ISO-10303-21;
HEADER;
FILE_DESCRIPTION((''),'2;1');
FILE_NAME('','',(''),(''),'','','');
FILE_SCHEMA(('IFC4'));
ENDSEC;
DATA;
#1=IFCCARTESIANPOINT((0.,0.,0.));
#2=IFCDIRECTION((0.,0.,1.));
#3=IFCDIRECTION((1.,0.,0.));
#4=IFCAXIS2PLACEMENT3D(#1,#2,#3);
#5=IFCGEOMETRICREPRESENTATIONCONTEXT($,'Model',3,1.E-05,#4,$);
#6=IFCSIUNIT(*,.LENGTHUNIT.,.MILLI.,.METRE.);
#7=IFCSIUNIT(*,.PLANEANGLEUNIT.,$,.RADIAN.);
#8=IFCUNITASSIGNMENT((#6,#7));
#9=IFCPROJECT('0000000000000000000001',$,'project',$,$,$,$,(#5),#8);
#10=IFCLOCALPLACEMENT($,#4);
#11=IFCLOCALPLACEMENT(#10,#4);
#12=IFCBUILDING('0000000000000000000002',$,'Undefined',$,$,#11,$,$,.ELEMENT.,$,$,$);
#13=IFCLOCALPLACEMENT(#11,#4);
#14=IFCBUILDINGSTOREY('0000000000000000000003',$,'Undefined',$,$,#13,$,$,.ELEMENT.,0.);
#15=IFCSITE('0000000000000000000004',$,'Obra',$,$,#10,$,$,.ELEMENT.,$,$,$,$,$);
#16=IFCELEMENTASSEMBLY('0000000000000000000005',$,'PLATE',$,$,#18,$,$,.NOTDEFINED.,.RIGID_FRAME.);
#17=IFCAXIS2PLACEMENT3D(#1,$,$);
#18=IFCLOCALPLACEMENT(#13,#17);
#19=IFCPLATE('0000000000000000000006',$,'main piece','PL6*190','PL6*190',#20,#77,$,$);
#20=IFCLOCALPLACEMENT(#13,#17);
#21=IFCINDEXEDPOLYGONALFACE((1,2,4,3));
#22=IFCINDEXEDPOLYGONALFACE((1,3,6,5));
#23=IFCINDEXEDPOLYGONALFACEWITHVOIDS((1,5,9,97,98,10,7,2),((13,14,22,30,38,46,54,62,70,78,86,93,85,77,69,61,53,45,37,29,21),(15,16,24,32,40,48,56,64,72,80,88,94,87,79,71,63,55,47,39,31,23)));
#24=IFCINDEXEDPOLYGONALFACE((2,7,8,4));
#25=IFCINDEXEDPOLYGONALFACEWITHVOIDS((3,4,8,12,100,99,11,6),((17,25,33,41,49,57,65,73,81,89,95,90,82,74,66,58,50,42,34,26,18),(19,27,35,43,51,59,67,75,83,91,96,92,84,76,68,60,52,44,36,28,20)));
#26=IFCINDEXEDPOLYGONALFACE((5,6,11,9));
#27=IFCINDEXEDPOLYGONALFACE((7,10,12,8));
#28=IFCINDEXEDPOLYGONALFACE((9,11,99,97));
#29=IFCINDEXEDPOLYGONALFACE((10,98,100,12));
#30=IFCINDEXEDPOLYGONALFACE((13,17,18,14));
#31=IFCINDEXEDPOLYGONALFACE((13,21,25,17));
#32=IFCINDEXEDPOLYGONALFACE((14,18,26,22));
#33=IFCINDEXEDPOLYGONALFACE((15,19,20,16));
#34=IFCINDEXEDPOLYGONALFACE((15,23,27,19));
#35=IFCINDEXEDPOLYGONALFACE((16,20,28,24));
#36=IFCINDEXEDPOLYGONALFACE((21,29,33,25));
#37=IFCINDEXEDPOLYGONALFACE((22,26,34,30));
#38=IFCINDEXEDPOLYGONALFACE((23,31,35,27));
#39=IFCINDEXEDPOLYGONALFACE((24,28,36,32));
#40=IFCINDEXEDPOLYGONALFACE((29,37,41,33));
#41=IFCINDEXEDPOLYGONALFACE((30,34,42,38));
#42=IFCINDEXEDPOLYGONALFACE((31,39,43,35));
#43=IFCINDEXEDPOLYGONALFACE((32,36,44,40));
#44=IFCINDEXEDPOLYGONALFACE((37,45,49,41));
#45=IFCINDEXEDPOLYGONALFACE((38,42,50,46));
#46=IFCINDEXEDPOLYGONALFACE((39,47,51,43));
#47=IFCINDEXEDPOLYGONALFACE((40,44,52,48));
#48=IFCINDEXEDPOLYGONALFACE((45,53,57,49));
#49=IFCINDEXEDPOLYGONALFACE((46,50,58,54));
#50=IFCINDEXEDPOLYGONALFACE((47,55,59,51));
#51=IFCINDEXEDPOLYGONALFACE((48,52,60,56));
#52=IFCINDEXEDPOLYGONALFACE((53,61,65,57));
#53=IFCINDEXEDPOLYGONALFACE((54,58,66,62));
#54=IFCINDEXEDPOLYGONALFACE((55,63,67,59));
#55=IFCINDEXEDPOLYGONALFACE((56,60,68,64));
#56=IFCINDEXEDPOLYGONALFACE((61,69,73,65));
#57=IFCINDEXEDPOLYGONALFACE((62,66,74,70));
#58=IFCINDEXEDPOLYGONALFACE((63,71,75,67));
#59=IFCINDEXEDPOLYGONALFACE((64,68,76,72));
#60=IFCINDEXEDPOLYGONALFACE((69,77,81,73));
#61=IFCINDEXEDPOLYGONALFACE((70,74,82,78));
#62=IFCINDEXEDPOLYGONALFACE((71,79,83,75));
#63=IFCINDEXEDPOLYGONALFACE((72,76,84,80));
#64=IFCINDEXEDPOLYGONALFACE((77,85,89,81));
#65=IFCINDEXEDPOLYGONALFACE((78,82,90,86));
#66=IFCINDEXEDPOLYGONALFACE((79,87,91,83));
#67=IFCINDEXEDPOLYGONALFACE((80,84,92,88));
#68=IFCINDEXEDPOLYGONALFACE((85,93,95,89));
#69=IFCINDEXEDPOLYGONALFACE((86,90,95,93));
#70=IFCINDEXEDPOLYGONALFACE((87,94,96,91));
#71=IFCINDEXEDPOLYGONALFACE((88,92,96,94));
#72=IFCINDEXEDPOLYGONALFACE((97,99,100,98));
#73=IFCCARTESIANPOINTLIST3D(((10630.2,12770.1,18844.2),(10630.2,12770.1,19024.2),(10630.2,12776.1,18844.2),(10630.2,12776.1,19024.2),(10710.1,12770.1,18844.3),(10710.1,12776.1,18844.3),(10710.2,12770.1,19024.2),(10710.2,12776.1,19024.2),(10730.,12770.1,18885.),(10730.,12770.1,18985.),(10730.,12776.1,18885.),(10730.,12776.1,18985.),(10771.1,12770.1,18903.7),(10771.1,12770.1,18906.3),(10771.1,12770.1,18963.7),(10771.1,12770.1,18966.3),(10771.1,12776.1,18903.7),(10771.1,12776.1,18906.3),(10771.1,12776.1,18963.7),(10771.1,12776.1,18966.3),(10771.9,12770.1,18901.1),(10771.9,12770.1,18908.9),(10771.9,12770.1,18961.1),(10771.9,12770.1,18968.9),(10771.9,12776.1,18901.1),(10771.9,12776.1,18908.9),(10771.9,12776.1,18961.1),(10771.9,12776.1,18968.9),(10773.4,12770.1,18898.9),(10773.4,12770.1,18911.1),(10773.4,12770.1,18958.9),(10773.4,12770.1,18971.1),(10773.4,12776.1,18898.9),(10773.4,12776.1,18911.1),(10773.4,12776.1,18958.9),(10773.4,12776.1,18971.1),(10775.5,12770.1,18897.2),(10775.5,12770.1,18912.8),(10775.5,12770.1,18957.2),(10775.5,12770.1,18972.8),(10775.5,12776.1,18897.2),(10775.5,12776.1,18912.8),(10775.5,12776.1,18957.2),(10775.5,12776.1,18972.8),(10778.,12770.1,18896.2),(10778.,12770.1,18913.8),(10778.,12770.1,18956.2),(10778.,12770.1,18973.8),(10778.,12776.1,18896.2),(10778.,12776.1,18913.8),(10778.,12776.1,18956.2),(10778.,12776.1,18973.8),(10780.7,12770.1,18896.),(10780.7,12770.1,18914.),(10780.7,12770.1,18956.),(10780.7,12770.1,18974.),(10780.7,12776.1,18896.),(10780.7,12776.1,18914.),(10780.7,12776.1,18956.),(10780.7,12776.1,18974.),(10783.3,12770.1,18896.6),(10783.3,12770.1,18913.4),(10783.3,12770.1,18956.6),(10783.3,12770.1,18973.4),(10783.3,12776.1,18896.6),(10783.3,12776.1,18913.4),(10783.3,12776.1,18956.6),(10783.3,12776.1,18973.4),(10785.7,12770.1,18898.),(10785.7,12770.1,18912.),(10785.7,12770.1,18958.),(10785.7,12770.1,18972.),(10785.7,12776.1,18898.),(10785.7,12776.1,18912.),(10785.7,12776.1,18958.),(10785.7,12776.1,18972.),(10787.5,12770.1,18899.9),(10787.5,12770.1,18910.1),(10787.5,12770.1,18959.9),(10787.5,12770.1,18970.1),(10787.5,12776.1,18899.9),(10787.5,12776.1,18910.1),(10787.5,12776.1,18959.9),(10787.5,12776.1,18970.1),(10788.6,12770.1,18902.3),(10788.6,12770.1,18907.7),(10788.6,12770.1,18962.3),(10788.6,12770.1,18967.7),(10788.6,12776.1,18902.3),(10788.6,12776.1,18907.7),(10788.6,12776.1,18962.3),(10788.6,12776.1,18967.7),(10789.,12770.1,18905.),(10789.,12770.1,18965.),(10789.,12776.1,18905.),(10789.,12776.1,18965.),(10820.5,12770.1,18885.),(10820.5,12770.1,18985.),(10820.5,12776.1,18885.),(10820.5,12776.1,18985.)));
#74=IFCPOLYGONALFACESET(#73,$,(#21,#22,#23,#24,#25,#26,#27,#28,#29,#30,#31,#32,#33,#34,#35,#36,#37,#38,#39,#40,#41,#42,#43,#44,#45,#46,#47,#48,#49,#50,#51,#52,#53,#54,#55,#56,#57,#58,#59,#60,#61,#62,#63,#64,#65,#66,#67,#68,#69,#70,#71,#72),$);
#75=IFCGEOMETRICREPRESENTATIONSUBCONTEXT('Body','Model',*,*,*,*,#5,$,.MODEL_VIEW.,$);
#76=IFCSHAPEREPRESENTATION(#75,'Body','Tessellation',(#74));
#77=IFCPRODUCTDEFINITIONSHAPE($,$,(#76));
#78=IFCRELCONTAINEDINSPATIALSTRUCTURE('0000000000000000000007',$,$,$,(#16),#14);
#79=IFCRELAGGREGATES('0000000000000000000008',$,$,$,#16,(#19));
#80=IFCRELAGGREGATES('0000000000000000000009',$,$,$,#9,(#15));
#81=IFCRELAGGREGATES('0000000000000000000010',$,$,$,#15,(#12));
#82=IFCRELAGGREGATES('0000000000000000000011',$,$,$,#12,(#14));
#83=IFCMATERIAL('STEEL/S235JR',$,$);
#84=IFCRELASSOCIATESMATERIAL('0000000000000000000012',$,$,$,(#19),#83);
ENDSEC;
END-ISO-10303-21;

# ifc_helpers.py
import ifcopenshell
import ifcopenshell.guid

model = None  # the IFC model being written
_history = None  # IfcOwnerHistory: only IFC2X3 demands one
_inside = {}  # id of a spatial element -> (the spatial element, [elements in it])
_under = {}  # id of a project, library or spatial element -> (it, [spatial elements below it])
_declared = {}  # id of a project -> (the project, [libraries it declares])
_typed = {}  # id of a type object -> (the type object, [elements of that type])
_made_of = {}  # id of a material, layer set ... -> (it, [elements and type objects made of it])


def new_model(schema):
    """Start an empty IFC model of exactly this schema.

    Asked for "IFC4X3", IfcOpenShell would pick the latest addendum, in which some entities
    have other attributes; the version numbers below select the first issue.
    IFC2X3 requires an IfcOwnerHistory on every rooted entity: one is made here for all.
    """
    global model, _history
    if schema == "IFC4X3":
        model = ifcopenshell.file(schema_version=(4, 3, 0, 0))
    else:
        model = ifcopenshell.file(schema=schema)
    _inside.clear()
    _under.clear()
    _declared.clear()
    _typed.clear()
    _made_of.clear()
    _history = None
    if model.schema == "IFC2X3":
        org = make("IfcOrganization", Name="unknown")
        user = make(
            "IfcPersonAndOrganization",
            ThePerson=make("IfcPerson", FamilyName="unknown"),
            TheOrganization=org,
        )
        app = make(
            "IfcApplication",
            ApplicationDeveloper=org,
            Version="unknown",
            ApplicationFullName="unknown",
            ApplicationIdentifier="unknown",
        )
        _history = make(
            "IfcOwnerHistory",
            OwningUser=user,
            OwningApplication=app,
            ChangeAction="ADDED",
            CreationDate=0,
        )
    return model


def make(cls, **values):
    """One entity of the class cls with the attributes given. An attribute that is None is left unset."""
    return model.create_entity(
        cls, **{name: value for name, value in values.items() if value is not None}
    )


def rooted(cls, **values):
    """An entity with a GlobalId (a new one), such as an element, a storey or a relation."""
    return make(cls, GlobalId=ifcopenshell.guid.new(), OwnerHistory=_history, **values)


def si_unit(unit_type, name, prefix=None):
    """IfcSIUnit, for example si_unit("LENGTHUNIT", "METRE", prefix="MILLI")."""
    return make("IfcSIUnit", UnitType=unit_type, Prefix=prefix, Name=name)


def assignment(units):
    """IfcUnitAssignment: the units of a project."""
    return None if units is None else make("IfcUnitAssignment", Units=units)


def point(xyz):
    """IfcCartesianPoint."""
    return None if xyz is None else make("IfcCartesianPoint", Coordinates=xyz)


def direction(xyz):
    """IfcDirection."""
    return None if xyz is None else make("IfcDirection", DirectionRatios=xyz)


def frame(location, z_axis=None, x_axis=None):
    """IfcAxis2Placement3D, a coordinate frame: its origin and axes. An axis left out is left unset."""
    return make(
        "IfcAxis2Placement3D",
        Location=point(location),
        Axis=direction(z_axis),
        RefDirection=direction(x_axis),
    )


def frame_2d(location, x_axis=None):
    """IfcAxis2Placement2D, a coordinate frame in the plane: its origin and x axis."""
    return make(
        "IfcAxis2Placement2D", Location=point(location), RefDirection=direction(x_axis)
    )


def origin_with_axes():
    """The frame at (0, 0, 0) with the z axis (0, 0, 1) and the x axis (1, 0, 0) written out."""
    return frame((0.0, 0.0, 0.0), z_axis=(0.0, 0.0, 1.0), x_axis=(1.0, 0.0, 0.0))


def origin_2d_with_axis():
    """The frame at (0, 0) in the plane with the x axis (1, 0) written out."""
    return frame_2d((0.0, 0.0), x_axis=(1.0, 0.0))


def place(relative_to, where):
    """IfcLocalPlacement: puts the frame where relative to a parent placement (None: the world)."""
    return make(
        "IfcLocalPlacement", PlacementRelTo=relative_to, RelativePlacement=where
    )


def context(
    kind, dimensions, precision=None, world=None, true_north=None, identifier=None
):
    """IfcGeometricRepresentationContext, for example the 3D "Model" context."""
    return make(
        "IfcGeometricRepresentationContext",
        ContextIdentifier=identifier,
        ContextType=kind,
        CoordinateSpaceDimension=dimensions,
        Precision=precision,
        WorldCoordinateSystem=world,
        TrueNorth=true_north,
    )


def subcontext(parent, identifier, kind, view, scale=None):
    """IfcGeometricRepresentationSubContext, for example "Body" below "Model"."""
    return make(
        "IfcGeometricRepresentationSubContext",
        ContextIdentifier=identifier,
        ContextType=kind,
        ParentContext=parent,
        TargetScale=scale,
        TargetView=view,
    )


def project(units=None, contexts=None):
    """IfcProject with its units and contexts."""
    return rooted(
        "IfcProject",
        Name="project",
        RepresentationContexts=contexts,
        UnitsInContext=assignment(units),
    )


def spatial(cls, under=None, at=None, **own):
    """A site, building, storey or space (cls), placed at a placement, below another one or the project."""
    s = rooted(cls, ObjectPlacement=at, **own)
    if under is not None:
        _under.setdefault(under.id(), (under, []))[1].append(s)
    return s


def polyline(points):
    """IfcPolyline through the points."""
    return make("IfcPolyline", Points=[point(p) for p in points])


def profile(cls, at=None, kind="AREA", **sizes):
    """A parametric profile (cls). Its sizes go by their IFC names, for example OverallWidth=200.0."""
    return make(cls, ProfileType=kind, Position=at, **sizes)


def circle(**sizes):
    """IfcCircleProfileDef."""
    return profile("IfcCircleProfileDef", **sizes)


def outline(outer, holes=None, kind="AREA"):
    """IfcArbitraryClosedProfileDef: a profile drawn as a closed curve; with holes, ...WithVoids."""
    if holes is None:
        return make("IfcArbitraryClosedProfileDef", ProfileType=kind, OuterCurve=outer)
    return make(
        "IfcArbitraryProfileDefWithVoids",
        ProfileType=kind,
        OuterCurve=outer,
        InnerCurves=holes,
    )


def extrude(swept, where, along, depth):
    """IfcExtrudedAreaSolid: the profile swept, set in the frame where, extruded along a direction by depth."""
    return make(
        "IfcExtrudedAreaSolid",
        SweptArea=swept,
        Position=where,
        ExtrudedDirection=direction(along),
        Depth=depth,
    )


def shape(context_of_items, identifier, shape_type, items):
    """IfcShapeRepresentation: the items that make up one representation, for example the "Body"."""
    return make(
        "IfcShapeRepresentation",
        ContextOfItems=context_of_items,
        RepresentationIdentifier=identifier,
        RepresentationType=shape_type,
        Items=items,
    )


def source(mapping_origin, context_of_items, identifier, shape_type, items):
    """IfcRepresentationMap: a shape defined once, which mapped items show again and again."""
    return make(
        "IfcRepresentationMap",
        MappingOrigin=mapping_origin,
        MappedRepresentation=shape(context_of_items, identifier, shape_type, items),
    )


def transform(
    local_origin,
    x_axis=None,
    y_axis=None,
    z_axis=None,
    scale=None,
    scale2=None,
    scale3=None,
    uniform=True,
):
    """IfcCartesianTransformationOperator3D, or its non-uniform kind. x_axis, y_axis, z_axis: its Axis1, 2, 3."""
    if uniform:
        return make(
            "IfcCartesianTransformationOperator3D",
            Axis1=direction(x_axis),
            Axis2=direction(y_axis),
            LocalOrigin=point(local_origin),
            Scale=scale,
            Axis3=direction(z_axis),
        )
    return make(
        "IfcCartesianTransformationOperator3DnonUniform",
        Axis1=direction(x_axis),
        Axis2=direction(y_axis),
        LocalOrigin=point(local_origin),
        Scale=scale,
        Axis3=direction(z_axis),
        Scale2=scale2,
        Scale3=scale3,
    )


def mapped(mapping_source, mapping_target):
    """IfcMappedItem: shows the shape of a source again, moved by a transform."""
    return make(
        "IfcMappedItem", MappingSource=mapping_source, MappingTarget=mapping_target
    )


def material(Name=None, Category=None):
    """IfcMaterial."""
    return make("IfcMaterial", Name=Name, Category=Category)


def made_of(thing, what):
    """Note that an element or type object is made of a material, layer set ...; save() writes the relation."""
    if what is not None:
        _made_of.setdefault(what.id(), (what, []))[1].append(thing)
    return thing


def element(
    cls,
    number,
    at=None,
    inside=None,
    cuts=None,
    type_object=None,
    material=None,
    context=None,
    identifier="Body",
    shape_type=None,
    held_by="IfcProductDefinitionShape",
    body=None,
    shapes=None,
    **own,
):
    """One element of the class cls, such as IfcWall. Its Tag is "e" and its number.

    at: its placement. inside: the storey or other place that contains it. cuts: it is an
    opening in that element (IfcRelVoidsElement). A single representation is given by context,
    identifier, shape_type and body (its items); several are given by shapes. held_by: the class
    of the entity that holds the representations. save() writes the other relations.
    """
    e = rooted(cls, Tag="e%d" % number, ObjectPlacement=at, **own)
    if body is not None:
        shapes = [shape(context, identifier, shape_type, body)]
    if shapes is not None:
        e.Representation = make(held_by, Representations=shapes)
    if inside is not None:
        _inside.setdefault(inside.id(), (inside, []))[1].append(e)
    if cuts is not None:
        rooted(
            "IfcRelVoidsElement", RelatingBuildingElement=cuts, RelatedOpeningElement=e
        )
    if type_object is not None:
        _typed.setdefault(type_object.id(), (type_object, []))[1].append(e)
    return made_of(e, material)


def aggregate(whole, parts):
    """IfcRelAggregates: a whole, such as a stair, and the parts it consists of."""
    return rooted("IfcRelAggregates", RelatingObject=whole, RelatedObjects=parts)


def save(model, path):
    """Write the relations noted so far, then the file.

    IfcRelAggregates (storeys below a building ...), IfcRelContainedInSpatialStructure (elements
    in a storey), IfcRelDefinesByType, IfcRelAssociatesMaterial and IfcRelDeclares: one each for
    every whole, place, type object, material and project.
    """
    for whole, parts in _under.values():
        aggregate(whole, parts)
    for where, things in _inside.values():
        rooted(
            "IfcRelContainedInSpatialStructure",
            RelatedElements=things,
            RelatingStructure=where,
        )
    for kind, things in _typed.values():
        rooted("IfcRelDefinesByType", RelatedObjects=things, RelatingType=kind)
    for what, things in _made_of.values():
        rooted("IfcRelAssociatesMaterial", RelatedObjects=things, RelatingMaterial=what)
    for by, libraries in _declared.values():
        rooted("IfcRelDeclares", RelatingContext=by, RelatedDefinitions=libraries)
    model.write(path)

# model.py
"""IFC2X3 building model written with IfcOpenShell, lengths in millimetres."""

from ifc_helpers import new_model, si_unit, frame, origin_with_axes, origin_2d_with_axis, place, context, subcontext, project, spatial, polyline, circle, outline, extrude, source, transform, mapped, material, element, aggregate, save


model = new_model("IFC2X3")

# Units and contexts
model_context = context("Model", 3, precision=1e-05, world=origin_with_axes())
body_context = subcontext(model_context, "Body", "Model", "MODEL_VIEW")
ifc_project = project(units=[si_unit("LENGTHUNIT", "METRE", prefix="MILLI"), si_unit("PLANEANGLEUNIT", "RADIAN")], contexts=[model_context])

# Site, building, storey
site_placement = place(None, origin_with_axes())
site = spatial("IfcSite", under=ifc_project, at=site_placement, Name="Obra", CompositionType="ELEMENT")
building_placement = place(site_placement, origin_with_axes())
building = spatial("IfcBuilding", under=site, at=building_placement, Name="Undefined", CompositionType="ELEMENT")
storey_placement = place(building_placement, origin_with_axes())
storey = spatial("IfcBuildingStorey", under=building, at=storey_placement, Name="Undefined", CompositionType="ELEMENT", Elevation=0.0)

# Shared definitions
ifc_material_1 = material(Name="STEEL/S235JR")

# Element assembly, plate, opening
shared_shape_1 = source(origin_with_axes(), body_context, "Body", "SweptSolid", [
    extrude(circle(Radius=9.0, at=origin_2d_with_axis()), frame((0.0, -6.1, 0.0), z_axis=(0.0, 1.0, 0.0), x_axis=(1.0, 0.0, 0.0)), (0.0, 0.0, 1.0), 6.2),
])
assembly_1_placement = place(storey_placement, origin_with_axes())
assembly_1 = element("IfcElementAssembly", 1, at=assembly_1_placement, inside=storey, Name="PLATE", AssemblyPlace="NOTDEFINED", PredefinedType="RIGID_FRAME")
plate_1_placement = place(assembly_1_placement, frame((10630.2, 12773.1, 19024.2), z_axis=(0.0, -1.0, 0.0), x_axis=(0.0, 0.0, -1.0)))
plate_1 = element("IfcPlate", 2, at=plate_1_placement, material=ifc_material_1, Name="main piece", Description="PL6*190", ObjectType="PL6*190", context=body_context, shape_type="SweptSolid", body=[
    extrude(outline(polyline([(0.0, 0.0), (180.0, 0.0), (180.0, 79.9), (139.2, 99.8), (139.2, 190.3), (39.2, 190.3), (39.2, 99.8), (0.0, 80.0), (0.0, 0.0)])), frame((0.0, 0.0, -3.0), z_axis=(0.0, 0.0, 1.0), x_axis=(1.0, 0.0, 0.0)), (0.0, 0.0, 1.0), 6.0),
])
opening_1_placement = place(assembly_1_placement, frame((10780.0, 12770.1, 18935.0), z_axis=(0.0, 0.0, -1.0), x_axis=(1.0, 0.0, 0.0)))
element("IfcOpeningElement", 3, at=opening_1_placement, cuts=plate_1, ObjectType="Opening", context=body_context, shape_type="MappedRepresentation", body=[
    mapped(shared_shape_1, transform((0.0, 0.0, 30.0))),
    mapped(shared_shape_1, transform((0.0, 0.0, -30.0))),
])

aggregate(assembly_1, [plate_1])

save(model, "model.ifc")
